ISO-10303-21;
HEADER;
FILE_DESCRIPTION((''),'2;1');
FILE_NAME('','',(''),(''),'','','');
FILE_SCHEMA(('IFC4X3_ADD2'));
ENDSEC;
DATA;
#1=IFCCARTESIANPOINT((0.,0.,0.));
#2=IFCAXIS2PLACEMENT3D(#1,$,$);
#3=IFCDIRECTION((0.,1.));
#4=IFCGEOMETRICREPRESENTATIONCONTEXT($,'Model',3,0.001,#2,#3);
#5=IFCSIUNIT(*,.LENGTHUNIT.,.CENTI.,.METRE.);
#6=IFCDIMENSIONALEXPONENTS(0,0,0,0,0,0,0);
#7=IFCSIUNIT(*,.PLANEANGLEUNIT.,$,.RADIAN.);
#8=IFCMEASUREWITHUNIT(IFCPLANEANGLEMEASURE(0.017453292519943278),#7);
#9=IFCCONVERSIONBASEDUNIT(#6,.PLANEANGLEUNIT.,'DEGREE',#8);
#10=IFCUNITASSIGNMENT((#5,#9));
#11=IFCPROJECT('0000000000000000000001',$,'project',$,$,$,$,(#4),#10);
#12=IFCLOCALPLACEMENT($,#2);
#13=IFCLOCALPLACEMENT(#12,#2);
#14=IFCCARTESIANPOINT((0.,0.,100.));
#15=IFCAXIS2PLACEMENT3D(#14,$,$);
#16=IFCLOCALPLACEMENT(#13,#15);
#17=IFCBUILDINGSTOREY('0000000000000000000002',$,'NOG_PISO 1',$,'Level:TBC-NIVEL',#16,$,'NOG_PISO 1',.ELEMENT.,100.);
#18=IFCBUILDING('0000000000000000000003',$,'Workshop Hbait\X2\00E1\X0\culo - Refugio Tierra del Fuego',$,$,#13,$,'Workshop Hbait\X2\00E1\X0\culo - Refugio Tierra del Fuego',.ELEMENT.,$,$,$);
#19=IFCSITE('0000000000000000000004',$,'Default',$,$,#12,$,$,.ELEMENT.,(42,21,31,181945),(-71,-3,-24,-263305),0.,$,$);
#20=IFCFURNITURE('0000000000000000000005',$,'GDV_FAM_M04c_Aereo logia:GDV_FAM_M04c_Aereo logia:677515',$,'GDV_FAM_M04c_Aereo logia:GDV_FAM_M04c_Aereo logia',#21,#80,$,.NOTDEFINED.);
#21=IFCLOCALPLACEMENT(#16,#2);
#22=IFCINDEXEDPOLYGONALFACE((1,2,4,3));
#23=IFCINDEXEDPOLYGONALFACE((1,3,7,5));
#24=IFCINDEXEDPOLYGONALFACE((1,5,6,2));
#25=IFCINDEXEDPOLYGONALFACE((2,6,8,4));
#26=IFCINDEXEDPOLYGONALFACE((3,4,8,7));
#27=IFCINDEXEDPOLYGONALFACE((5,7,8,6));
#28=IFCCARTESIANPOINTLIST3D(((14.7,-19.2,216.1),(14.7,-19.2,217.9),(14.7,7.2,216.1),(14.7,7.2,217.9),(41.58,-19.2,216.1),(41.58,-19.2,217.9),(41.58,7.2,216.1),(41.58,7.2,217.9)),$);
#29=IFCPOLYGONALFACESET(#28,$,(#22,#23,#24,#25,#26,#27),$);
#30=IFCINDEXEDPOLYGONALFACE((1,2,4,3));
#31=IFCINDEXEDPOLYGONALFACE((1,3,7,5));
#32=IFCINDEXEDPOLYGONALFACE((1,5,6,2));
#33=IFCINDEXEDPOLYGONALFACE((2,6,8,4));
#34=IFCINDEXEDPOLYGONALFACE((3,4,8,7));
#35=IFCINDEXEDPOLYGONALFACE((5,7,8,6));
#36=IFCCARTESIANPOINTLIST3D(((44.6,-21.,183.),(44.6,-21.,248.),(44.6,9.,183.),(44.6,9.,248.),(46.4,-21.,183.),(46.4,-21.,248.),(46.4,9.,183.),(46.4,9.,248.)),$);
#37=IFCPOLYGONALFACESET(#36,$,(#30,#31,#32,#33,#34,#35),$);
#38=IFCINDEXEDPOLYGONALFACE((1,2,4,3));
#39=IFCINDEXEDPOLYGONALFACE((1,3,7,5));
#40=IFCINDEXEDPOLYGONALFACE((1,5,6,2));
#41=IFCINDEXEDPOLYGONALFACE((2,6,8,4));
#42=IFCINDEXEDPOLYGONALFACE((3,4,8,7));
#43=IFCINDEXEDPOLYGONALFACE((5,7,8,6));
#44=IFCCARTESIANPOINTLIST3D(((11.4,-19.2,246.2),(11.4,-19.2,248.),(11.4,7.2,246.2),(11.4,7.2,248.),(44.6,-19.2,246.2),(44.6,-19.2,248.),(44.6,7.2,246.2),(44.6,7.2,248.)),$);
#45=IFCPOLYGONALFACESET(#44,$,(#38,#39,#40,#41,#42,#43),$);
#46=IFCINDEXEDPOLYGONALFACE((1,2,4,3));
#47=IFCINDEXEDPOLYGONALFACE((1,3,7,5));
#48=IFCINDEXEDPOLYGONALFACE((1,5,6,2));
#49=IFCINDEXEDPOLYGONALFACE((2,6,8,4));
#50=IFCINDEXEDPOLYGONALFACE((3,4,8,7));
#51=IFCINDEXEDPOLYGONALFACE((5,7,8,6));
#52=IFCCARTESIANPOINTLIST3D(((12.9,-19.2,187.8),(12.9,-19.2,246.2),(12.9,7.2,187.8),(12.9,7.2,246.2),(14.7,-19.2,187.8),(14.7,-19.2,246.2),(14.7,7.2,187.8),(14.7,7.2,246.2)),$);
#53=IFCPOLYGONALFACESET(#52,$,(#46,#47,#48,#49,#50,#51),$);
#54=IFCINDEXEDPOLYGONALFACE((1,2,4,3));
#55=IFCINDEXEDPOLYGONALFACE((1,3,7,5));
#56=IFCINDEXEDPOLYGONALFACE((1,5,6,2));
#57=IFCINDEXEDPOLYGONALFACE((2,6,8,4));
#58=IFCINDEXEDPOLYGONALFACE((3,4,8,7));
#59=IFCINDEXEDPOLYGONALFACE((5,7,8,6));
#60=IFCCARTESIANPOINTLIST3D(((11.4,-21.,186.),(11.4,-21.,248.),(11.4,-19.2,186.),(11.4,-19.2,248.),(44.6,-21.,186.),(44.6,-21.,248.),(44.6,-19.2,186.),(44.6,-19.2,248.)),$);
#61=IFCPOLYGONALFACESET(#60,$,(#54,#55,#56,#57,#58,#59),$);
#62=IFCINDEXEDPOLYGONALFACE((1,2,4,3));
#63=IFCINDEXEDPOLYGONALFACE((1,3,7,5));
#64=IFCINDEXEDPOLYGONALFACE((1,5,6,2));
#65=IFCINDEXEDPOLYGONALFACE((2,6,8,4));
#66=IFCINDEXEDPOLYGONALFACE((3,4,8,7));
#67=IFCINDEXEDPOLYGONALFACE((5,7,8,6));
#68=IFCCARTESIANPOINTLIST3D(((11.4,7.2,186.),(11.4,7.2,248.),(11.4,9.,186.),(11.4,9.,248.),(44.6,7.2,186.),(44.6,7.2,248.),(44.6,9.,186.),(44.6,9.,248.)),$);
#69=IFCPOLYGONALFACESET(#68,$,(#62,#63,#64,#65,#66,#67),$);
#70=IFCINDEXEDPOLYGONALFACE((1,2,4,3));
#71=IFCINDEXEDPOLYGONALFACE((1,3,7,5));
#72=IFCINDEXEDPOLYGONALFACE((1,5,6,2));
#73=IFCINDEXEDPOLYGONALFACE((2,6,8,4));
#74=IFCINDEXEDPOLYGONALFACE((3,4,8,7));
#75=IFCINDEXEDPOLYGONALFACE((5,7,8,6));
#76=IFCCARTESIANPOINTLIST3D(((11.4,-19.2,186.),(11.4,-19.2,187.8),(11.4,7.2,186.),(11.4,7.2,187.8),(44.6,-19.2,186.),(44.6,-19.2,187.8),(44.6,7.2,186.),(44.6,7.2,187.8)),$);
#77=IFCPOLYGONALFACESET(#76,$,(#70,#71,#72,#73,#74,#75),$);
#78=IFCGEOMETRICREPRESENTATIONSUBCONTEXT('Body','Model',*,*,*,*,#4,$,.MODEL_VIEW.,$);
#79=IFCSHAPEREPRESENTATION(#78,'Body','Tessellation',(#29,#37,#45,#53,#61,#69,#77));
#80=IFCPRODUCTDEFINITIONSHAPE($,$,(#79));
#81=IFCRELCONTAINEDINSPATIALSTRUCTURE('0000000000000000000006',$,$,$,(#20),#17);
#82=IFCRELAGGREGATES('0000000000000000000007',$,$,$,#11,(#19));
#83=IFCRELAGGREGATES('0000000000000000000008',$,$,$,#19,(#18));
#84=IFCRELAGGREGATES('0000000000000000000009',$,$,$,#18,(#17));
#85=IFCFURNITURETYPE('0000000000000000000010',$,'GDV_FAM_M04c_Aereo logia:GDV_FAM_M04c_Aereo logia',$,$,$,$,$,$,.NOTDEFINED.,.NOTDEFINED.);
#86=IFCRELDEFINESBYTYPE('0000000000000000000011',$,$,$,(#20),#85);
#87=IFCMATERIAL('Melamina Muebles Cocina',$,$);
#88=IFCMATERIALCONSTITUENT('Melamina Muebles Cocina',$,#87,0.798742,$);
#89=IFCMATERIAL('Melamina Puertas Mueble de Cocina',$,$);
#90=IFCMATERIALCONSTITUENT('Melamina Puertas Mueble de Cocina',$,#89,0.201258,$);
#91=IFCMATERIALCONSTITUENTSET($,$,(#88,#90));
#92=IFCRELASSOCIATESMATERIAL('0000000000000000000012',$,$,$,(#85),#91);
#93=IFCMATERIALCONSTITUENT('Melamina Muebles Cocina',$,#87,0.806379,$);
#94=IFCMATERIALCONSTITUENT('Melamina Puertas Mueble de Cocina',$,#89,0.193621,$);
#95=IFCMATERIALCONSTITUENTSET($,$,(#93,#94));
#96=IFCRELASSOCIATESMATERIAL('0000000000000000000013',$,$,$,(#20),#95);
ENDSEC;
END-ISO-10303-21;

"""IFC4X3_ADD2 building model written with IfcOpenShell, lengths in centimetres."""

from ifc_helpers import new_model, entity, si_unit, converted_unit, direction, frame, frame_2d, origin, origin_2d_with_axis, place, context, subcontext, project, spatial, rectangle, extrude, source, transform, mapped, material, constituent, constituent_set, type_object, type_shapes, element, save


model = new_model("IFC4X3_ADD2")

# Units and contexts
model_context = context("Model", 3, precision=0.001, world=origin(), true_north=direction((0.0, 1.0)))
body_context = subcontext(model_context, "Body", "Model", "MODEL_VIEW")
ifc_project = project(units=[si_unit("LENGTHUNIT", "METRE", prefix="CENTI"), converted_unit("PLANEANGLEUNIT", "DEGREE", entity("IfcPlaneAngleMeasure", 0.017453292519943278), si_unit("PLANEANGLEUNIT", "RADIAN"), dimensions=[0, 0, 0, 0, 0, 0, 0])], contexts=[model_context])

# Site, building, storey
site_placement = place(None, origin())
site = spatial("IfcSite", under=ifc_project, at=site_placement, Name="Default", CompositionType="ELEMENT", RefLatitude=(42, 21, 31, 181945), RefLongitude=(-71, -3, -24, -263305), RefElevation=0.0)
building_placement = place(site_placement, origin())
building = spatial("IfcBuilding", under=site, at=building_placement, Name="Workshop Hbaitáculo - Refugio Tierra del Fuego", LongName="Workshop Hbaitáculo - Refugio Tierra del Fuego", CompositionType="ELEMENT")
storey_placement = place(building_placement, frame((0.0, 0.0, 100.0)))
storey = spatial("IfcBuildingStorey", under=building, at=storey_placement, Name="NOG_PISO 1", ObjectType="Level:TBC-NIVEL", LongName="NOG_PISO 1", CompositionType="ELEMENT", Elevation=100.0)

# Furniture
ifc_material_1 = material(Name="Melamina Puertas Mueble de Cocina")
ifc_material_2 = material(Name="Melamina Muebles Cocina")
ifc_constituent_1 = constituent(ifc_material_2, Name="Melamina Muebles Cocina", fraction=0.806379)
ifc_constituent_2 = constituent(ifc_material_1, Name="Melamina Puertas Mueble de Cocina", fraction=0.193621)
ifc_constituent_set_1 = constituent_set(constituents=[ifc_constituent_1, ifc_constituent_2])
ifc_constituent_3 = constituent(ifc_material_2, Name="Melamina Muebles Cocina", fraction=0.798742)
ifc_constituent_4 = constituent(ifc_material_1, Name="Melamina Puertas Mueble de Cocina", fraction=0.201258)
ifc_constituent_set_2 = constituent_set(constituents=[ifc_constituent_3, ifc_constituent_4])
furniture_type_1 = type_object("IfcFurnitureType", Name="GDV_FAM_M04c_Aereo logia:GDV_FAM_M04c_Aereo logia", AssemblyPlace="NOTDEFINED", PredefinedType="NOTDEFINED", material=ifc_constituent_set_2)
shared_shape_1 = source(origin(), body_context, "Body", "SweptSolid", [
    extrude(rectangle(XDim=26.88, YDim=26.4, at=frame_2d((0.0, 0.0), x_axis=(1.0, 0.0))), frame((15.0, 16.74, 33.1), z_axis=(0.0, 0.0, 1.0), x_axis=(0.0, 1.0, 0.0)), (0.0, 0.0, 1.0), 1.8),
    extrude(rectangle(XDim=1.8, YDim=30.0, at=frame_2d((0.0, 0.0), x_axis=(1.0, 0.0))), frame((15.0, 34.1, 0.0), z_axis=(0.0, 0.0, 1.0), x_axis=(0.0, 1.0, 0.0)), (0.0, 0.0, 1.0), 65.0),
    extrude(rectangle(XDim=33.2, YDim=26.4, at=frame_2d((0.0, 0.0), x_axis=(1.0, 0.0))), frame((15.0, 16.6, 63.2), z_axis=(0.0, 0.0, 1.0), x_axis=(0.0, 1.0, 0.0)), (0.0, 0.0, 1.0), 1.8),
    extrude(rectangle(XDim=1.8, YDim=26.4, at=origin_2d_with_axis()), frame((15.0, 2.4, 4.8), z_axis=(0.0, 0.0, 1.0), x_axis=(0.0, 1.0, 0.0)), (0.0, 0.0, 1.0), 58.4),
    extrude(rectangle(XDim=1.8, YDim=33.2, at=origin_2d_with_axis()), frame((29.1, 16.6, 3.0), z_axis=(0.0, 0.0, 1.0), x_axis=(-1.0, 0.0, 0.0)), (0.0, 0.0, 1.0), 62.0),
    extrude(rectangle(XDim=1.8, YDim=33.2, at=origin_2d_with_axis()), frame((0.9, 16.6, 3.0), z_axis=(0.0, 0.0, 1.0), x_axis=(-1.0, 0.0, 0.0)), (0.0, 0.0, 1.0), 62.0),
    extrude(rectangle(XDim=33.2, YDim=26.4, at=origin_2d_with_axis()), frame((15.0, 16.6, 3.0), z_axis=(0.0, 0.0, 1.0), x_axis=(0.0, 1.0, 0.0)), (0.0, 0.0, 1.0), 1.8),
])
type_shapes(furniture_type_1, [shared_shape_1])
furniture_1_placement = place(storey_placement, frame((11.4, 9.0, 183.0), z_axis=(0.0, 0.0, 1.0), x_axis=(0.0, -1.0, 0.0)))
element("IfcFurniture", 1, at=furniture_1_placement, inside=storey, type_object=furniture_type_1, material=ifc_constituent_set_1, Name="GDV_FAM_M04c_Aereo logia:GDV_FAM_M04c_Aereo logia:677515", ObjectType="GDV_FAM_M04c_Aereo logia:GDV_FAM_M04c_Aereo logia", PredefinedType="NOTDEFINED", context=body_context, shape_type="MappedRepresentation", body=[
    mapped(shared_shape_1, transform((0.0, 0.0, 0.0), scale=1.0)),
])

save(model, "model.ifc")
